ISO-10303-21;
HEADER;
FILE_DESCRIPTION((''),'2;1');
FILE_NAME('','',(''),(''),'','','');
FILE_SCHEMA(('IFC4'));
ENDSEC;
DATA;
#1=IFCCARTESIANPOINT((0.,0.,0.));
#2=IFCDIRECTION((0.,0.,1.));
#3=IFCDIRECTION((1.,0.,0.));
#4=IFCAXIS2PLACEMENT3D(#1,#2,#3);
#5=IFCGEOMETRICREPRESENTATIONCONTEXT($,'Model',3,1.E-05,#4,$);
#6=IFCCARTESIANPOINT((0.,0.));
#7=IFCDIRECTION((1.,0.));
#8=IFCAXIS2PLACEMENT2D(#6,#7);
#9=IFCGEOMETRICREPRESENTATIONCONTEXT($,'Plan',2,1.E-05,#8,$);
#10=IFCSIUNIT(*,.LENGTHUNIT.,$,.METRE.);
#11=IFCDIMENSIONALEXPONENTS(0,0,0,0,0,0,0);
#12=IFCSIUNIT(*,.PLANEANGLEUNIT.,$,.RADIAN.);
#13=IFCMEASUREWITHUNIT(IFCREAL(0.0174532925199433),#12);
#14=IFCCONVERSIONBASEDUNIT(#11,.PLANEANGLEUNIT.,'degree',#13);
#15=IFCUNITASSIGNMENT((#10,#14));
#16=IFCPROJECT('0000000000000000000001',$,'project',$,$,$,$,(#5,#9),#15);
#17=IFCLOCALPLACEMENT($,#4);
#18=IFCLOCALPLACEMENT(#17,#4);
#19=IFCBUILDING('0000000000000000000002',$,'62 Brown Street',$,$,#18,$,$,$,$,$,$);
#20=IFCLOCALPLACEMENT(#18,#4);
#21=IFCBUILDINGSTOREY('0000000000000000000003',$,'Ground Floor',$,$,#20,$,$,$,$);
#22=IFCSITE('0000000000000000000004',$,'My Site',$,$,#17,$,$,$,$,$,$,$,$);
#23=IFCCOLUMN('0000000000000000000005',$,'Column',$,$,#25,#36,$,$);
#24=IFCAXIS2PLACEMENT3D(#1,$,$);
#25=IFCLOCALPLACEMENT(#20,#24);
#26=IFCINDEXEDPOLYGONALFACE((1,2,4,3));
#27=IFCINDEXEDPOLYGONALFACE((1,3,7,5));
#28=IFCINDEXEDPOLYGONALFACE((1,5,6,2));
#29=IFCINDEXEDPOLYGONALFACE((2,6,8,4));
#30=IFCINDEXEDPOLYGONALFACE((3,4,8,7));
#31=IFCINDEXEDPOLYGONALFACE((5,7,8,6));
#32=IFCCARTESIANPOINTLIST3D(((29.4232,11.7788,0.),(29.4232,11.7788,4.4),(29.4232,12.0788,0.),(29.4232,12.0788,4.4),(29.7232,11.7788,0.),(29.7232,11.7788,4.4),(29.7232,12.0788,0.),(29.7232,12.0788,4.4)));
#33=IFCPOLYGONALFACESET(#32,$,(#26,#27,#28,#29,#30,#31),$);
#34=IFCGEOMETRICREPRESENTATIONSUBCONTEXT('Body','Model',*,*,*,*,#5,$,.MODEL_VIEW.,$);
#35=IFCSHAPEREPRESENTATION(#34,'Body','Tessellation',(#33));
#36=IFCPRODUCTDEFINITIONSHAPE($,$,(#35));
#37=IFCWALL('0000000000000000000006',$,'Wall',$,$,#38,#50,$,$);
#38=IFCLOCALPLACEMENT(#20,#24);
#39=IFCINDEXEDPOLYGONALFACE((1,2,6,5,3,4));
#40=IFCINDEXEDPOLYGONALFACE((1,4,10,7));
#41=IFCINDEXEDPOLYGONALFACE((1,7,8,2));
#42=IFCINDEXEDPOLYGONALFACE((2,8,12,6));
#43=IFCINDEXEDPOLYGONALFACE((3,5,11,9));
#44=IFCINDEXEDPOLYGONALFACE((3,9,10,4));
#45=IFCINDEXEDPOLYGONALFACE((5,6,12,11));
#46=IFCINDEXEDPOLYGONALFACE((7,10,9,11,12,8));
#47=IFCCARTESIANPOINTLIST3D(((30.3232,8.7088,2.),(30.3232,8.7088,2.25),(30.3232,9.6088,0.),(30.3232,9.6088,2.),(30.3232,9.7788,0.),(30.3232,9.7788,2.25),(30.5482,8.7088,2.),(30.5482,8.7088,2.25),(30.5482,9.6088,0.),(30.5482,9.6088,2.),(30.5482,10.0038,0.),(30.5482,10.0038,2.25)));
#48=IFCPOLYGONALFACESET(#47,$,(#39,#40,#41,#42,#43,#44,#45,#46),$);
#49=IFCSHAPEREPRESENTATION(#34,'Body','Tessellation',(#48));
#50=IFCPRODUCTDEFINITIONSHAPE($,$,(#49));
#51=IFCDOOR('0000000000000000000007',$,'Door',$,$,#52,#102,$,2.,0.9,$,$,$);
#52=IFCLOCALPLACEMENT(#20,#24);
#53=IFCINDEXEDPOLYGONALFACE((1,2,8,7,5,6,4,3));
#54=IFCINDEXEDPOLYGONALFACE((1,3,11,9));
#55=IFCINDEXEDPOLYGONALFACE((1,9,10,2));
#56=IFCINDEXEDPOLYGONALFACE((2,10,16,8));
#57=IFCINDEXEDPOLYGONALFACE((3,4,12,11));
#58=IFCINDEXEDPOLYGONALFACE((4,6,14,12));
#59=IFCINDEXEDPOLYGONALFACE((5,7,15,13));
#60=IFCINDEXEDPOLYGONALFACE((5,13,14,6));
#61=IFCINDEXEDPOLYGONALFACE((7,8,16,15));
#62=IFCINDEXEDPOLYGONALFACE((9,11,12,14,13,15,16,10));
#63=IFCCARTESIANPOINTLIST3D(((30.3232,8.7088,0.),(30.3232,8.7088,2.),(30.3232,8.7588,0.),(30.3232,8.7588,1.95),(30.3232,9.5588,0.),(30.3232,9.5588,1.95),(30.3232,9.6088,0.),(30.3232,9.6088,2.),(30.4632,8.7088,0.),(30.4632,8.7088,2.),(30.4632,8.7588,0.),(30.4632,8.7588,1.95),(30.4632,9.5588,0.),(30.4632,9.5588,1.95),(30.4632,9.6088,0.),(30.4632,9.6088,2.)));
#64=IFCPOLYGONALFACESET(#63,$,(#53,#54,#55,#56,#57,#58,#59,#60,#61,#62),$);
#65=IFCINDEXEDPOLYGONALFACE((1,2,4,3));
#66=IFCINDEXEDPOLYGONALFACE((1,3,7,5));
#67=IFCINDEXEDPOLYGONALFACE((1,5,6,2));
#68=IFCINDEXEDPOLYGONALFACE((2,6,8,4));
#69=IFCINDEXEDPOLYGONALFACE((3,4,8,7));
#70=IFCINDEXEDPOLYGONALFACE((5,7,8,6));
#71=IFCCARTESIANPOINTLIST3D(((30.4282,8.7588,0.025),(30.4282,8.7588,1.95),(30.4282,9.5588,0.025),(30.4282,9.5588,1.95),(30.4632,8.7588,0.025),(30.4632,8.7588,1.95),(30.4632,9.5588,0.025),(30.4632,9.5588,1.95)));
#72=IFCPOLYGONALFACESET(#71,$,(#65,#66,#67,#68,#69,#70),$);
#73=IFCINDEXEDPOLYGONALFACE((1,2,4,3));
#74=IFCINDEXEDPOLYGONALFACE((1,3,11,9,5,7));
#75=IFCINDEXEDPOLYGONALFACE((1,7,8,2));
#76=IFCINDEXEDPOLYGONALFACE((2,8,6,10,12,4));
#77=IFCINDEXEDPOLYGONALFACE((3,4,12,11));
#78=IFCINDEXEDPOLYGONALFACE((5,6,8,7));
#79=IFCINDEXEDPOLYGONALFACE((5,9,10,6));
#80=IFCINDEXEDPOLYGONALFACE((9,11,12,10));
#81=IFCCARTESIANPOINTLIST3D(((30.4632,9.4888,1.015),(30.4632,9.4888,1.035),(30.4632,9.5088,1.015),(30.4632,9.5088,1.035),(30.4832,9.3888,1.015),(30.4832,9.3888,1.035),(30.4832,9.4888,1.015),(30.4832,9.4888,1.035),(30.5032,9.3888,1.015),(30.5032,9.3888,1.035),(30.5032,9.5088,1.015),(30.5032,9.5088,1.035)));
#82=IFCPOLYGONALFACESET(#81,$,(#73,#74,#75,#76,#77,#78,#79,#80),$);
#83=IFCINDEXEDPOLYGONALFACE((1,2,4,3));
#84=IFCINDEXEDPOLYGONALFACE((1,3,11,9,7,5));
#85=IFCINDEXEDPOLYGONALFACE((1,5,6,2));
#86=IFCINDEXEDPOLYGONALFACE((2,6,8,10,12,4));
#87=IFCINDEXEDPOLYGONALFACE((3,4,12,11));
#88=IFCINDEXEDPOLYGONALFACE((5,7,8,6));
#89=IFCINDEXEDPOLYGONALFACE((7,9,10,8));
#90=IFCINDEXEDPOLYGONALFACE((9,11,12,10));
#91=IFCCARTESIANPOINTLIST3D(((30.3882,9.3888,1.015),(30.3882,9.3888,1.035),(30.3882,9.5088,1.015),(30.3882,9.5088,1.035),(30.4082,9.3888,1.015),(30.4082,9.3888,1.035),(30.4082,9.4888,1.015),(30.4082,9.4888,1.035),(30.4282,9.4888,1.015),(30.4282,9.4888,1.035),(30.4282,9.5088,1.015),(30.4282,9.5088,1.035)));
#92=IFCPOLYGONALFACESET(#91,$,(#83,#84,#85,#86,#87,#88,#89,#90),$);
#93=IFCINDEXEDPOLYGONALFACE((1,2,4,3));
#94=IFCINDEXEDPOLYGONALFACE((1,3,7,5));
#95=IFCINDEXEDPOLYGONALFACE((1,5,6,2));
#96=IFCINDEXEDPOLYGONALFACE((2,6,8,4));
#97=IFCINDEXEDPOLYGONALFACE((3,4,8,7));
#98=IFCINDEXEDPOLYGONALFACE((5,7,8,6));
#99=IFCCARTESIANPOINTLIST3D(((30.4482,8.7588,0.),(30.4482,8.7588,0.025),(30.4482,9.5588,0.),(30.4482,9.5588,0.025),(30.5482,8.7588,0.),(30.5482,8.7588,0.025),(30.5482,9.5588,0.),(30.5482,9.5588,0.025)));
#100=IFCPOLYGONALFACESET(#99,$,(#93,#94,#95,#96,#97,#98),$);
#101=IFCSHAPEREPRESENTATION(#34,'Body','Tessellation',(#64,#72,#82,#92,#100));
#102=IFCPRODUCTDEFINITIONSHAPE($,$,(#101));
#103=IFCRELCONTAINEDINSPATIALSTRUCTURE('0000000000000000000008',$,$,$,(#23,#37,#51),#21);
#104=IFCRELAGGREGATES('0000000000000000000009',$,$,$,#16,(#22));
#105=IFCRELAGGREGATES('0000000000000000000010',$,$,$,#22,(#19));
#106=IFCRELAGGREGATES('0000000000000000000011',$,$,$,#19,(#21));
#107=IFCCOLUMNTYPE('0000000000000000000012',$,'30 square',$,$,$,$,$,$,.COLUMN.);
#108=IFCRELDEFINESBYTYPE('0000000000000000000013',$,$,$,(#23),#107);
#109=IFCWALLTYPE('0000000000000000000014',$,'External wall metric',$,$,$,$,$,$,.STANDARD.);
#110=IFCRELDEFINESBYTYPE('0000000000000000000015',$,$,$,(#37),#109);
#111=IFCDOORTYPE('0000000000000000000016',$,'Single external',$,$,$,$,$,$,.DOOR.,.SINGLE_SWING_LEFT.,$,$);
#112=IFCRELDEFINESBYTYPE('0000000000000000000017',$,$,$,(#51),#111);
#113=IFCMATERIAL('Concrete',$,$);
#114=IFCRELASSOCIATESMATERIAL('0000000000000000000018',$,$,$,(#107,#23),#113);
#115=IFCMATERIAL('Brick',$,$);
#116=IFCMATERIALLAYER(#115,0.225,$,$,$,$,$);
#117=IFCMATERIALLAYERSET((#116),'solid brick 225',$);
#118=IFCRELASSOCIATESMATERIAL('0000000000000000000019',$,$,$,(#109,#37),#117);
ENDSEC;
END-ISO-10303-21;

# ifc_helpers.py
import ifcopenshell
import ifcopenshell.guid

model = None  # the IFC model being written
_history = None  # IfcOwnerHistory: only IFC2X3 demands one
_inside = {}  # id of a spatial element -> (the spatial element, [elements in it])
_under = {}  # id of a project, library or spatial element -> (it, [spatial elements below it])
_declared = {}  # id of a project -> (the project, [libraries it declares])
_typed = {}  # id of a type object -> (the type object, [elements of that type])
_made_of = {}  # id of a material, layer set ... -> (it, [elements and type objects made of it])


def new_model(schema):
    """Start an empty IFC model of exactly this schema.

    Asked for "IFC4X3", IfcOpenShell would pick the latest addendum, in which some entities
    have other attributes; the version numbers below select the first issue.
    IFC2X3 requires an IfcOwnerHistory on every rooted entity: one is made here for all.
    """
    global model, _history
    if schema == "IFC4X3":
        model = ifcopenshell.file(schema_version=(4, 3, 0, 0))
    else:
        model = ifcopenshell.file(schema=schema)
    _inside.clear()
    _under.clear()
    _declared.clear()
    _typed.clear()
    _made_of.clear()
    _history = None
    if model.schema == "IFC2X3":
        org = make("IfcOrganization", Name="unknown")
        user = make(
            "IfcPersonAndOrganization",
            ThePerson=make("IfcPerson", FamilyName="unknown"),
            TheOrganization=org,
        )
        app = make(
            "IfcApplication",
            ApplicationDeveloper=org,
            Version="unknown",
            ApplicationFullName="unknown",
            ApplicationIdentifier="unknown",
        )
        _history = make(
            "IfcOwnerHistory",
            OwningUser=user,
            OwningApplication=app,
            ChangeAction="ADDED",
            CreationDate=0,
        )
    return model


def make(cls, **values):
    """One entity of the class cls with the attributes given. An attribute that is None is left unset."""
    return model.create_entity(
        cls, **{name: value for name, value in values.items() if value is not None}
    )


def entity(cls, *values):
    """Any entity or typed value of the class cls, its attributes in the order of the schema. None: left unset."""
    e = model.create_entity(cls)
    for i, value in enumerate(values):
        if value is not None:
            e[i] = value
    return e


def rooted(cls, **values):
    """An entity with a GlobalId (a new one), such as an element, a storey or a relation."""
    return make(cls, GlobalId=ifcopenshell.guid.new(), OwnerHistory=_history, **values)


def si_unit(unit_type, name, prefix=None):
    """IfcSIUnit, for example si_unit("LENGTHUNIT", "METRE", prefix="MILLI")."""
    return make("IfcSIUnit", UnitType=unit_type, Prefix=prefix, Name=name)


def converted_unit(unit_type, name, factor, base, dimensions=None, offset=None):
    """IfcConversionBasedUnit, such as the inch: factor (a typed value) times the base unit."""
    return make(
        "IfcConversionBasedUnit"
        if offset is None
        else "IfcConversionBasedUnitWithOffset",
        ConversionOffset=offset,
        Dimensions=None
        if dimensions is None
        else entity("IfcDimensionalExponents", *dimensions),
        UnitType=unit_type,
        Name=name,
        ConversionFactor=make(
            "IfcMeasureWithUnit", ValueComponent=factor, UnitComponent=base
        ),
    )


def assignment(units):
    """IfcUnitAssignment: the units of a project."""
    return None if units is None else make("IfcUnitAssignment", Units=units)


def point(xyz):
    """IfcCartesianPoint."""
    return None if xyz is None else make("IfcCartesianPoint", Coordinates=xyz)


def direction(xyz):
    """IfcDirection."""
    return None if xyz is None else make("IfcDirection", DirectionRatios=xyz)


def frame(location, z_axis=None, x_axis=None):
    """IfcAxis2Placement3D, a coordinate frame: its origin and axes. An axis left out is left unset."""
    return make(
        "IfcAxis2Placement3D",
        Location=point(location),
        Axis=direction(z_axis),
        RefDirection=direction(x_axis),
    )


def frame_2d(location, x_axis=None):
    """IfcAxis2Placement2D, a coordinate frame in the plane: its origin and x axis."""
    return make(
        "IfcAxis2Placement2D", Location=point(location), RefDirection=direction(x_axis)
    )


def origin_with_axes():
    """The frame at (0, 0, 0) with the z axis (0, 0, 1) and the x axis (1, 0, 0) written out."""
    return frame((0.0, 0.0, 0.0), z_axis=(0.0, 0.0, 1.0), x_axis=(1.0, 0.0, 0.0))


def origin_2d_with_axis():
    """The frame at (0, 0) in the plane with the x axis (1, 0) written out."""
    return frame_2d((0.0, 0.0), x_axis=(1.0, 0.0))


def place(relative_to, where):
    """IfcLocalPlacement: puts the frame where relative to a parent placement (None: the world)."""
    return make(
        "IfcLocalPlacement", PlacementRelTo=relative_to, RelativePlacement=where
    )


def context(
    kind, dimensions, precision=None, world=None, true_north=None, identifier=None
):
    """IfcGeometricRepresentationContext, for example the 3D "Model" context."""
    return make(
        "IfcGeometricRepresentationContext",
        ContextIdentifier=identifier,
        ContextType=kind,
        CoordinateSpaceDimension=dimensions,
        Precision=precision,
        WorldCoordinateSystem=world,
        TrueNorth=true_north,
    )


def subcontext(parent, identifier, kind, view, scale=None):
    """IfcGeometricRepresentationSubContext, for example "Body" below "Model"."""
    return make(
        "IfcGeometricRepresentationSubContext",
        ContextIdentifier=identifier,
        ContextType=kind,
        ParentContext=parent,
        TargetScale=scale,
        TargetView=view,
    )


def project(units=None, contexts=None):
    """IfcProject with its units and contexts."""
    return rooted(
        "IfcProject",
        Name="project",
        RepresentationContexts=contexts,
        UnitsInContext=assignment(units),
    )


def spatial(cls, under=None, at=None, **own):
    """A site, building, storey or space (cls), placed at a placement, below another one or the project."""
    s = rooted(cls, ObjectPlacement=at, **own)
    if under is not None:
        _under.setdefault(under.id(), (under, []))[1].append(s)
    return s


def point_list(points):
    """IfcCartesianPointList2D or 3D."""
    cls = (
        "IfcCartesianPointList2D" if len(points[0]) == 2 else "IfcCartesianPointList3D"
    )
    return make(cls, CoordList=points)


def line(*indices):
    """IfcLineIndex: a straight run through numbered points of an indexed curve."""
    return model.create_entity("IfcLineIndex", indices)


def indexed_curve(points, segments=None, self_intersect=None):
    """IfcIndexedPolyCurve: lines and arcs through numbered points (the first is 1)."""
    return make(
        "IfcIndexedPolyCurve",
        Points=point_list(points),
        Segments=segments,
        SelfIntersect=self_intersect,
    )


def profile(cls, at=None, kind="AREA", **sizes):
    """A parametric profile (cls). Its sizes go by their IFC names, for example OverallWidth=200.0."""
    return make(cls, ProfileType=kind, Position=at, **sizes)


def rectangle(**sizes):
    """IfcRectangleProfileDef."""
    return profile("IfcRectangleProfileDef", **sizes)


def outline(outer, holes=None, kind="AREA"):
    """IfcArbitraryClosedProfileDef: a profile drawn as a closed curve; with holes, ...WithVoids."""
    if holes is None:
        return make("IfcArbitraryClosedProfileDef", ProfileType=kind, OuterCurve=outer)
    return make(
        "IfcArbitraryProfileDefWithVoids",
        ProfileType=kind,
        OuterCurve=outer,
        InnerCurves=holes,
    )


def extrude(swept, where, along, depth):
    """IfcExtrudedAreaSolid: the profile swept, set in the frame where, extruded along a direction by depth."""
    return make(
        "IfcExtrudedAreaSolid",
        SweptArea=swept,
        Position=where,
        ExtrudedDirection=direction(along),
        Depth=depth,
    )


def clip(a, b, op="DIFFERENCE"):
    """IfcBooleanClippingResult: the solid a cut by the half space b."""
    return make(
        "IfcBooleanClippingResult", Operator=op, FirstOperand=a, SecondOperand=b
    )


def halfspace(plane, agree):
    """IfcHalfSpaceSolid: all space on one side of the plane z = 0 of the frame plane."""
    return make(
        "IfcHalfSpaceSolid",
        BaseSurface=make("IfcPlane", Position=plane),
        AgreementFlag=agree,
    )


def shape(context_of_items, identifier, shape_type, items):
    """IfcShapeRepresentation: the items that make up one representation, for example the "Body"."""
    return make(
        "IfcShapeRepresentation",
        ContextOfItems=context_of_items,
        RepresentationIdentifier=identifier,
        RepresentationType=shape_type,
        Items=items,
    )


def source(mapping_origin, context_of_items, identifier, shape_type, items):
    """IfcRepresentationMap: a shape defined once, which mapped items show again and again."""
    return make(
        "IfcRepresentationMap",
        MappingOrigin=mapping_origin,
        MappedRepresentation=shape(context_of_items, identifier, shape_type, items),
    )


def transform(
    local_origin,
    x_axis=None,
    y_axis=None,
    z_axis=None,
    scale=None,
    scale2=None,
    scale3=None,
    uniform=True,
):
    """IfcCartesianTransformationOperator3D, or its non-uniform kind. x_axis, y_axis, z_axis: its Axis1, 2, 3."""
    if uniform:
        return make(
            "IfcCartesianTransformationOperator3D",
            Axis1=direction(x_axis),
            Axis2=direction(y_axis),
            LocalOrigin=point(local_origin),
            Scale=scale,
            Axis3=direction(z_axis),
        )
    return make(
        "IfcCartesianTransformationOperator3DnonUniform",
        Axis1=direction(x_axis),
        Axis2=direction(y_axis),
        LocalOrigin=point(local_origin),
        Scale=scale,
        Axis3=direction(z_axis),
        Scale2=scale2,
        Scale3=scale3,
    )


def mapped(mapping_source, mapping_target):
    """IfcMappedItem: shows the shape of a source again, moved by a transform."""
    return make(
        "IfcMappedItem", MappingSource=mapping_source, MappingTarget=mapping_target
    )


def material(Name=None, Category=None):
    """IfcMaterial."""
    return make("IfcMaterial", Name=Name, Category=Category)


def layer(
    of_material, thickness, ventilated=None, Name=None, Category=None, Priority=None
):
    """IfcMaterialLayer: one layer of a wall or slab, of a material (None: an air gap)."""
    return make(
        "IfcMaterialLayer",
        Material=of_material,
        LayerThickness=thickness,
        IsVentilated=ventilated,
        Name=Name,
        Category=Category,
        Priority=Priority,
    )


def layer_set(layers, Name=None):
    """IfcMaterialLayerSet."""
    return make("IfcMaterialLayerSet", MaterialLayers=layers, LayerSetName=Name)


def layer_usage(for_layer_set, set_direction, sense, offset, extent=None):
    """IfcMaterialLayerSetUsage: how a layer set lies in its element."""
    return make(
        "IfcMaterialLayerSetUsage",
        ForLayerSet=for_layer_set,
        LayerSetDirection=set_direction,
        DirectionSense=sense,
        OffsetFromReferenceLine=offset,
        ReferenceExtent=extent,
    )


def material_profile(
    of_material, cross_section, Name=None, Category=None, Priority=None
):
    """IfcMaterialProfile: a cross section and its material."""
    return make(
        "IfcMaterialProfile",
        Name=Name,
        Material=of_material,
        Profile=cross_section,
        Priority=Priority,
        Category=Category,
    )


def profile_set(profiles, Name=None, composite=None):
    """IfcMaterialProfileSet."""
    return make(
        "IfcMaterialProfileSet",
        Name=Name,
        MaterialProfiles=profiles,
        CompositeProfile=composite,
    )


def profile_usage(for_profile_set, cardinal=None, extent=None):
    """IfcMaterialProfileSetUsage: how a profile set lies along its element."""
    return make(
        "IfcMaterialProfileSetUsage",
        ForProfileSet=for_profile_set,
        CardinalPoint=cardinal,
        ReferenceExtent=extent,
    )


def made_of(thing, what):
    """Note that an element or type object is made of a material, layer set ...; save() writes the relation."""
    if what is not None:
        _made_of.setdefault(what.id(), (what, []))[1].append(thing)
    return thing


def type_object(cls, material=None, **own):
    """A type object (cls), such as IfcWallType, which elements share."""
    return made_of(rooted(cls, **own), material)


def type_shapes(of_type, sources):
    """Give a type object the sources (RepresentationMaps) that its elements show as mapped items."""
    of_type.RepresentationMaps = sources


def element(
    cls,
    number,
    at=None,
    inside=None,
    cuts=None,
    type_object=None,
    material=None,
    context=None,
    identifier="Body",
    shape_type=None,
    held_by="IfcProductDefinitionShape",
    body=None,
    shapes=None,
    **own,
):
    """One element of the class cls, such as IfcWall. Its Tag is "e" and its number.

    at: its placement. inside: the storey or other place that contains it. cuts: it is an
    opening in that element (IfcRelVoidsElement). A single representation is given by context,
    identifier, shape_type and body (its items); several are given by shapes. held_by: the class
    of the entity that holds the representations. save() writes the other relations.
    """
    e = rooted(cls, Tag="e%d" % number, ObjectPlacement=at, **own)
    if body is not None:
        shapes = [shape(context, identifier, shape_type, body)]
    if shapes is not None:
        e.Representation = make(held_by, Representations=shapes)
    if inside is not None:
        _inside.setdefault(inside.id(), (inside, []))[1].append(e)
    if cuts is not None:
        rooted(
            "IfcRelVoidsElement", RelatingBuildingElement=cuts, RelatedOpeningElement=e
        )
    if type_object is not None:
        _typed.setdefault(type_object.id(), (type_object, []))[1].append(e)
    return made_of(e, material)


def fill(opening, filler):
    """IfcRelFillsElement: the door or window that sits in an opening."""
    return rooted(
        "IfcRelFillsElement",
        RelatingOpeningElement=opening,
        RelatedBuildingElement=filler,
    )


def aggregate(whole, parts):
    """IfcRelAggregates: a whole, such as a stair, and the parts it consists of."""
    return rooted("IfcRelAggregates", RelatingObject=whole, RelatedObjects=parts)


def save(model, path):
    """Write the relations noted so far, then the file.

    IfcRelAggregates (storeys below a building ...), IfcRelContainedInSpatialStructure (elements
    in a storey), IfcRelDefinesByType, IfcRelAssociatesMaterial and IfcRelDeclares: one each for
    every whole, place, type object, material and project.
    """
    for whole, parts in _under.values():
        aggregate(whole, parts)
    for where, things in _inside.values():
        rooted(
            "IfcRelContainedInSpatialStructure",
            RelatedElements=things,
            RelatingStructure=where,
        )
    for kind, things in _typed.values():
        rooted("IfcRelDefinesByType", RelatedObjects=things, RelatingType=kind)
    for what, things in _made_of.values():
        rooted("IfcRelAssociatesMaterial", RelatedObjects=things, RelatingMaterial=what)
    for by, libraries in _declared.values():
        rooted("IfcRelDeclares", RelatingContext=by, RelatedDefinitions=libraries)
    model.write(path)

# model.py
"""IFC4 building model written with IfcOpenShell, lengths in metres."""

from ifc_helpers import new_model, entity, si_unit, converted_unit, frame, origin_with_axes, origin_2d_with_axis, place, context, subcontext, project, spatial, line, indexed_curve, rectangle, outline, extrude, clip, halfspace, shape, source, transform, mapped, material, layer, layer_set, layer_usage, material_profile, profile_set, profile_usage, type_object, type_shapes, element, fill, save


model = new_model("IFC4")

# Units and contexts
model_context = context("Model", 3, precision=1e-05, world=origin_with_axes())
plan_context = context("Plan", 2, precision=1e-05, world=origin_2d_with_axis())
body_context_1 = subcontext(model_context, "Body", "Model", "MODEL_VIEW")
body_context_2 = subcontext(plan_context, "Body", "Plan", "PLAN_VIEW")
ifc_project = project(units=[si_unit("LENGTHUNIT", "METRE"), converted_unit("PLANEANGLEUNIT", "degree", entity("IfcReal", 0.0174532925199433), si_unit("PLANEANGLEUNIT", "RADIAN"), dimensions=[0, 0, 0, 0, 0, 0, 0])], contexts=[model_context, plan_context])

# Site, building, storey
site_placement = place(None, origin_with_axes())
site = spatial("IfcSite", under=ifc_project, at=site_placement, Name="My Site")
building_placement = place(site_placement, origin_with_axes())
building = spatial("IfcBuilding", under=site, at=building_placement, Name="62 Brown Street")
storey_placement = place(building_placement, origin_with_axes())
storey = spatial("IfcBuildingStorey", under=building, at=storey_placement, Name="Ground Floor")

# Column
ifc_material_1 = material(Name="Concrete")
ifc_material_profile = material_profile(ifc_material_1, rectangle(XDim=0.3, YDim=0.3))
ifc_profile_set = profile_set([ifc_material_profile])
ifc_profile_usage = profile_usage(ifc_profile_set, cardinal=5)
column_type = type_object("IfcColumnType", Name="30 square", PredefinedType="COLUMN", material=ifc_profile_set)
column_placement = place(storey_placement, frame((29.5732, 11.9288, 0.0), z_axis=(0.0, 0.0, 1.0), x_axis=(1.0, 0.0, 0.0)))
element("IfcColumn", 1, at=column_placement, inside=storey, type_object=column_type, material=ifc_profile_usage, Name="Column", context=body_context_1, shape_type="SweptSolid", body=[
    extrude(rectangle(XDim=0.3, YDim=0.3), origin_with_axes(), (0.0, 0.0, 1.0), 4.4),
])

# Shared definitions
ifc_material_2 = material(Name="Brick")
ifc_layer_1 = layer(ifc_material_2, 0.225)
ifc_layer_set_1 = layer_set([ifc_layer_1], Name="solid brick 225")
wall_type_1 = type_object("IfcWallType", Name="External wall metric", PredefinedType="STANDARD", material=ifc_layer_set_1)

# Wall, opening, door
ifc_layer_usage_1 = layer_usage(ifc_layer_set_1, "AXIS2", "POSITIVE", 0.0)
wall_1_placement = place(storey_placement, frame((30.5482, 8.7088, 0.0), z_axis=(0.0, 0.0, 1.0), x_axis=(0.0, 1.0, 0.0)))
wall_1 = element("IfcWall", 2, at=wall_1_placement, inside=storey, type_object=wall_type_1, material=ifc_layer_usage_1, Name="Wall", context=body_context_1, shape_type="Clipping", body=[
    clip(extrude(outline(indexed_curve([(0.0, 0.0), (0.0, 0.225), (1.295, 0.225), (1.295, 0.0), (0.0, 0.0)], self_intersect=False)), origin_with_axes(), (0.0, 0.0, 1.0), 2.25), halfspace(frame((1.295, 0.0, 0.0), z_axis=(0.506251, 0.506251, 0.0), x_axis=(-0.225, 0.225, 0.0)), False)),
])
shared_shape_1 = source(origin_with_axes(), body_context_1, "Body", "SweptSolid", [
    extrude(outline(indexed_curve([(0.0, 0.0), (0.9, 0.0), (0.9, 2.0), (0.0, 2.0)], segments=[line(1, 2, 3, 4, 1)])), frame((0.0, -0.6, 0.0), z_axis=(0.0, -1.0, 0.0), x_axis=(1.0, 0.0, 0.0)), (0.0, 0.0, -1.0), 1.2),
])
opening_1_placement = place(wall_1_placement, frame((0.0, 0.0, 0.0), z_axis=(0.0, 0.0, 1.0), x_axis=(1.0, 0.0, 0.0)))
opening_1 = element("IfcOpeningElement", 3, at=opening_1_placement, cuts=wall_1, PredefinedType="OPENING", context=body_context_1, shape_type="MappedRepresentation", body=[
    mapped(shared_shape_1, transform((0.0, 0.0, 0.0), x_axis=(1.0, 0.0, 0.0), y_axis=(0.0, 1.0, 0.0), z_axis=(0.0, 0.0, 1.0), scale=1.0)),
])
door_type_1 = type_object("IfcDoorType", Name="Single external", OperationType="SINGLE_SWING_LEFT", PredefinedType="DOOR")
shared_shape_2 = source(origin_with_axes(), body_context_1, "Body", "SweptSolid", [
    extrude(outline(indexed_curve([(0.0, 0.0), (0.0, 2.0), (0.9, 2.0), (0.9, 0.0), (0.85, 0.0), (0.85, 1.95), (0.05, 1.95), (0.05, 0.0)], segments=[line(1, 2, 3, 4, 5, 6, 7, 8, 1)])), frame((0.0, 0.085, 0.0), z_axis=(0.0, -1.0, 0.0), x_axis=(1.0, 0.0, 0.0)), (0.0, 0.0, -1.0), 0.14),
    extrude(outline(indexed_curve([(0.0, 0.0), (0.8, 0.0), (0.8, 0.035), (0.0, 0.035)], segments=[line(1, 2, 3, 4, 1)])), frame((0.05, 0.085, 0.025), z_axis=(0.0, 0.0, 1.0), x_axis=(1.0, 0.0, 0.0)), (0.0, 0.0, 1.0), 1.925),
    extrude(outline(indexed_curve([(0.0, 0.0), (0.0, -0.04), (-0.12, -0.04), (-0.12, -0.02), (-0.02, -0.02), (-0.02, 0.0)], segments=[line(1, 2, 3, 4, 5, 6, 1)])), frame((0.8, 0.085, 1.015), z_axis=(0.0, 0.0, 1.0), x_axis=(1.0, 0.0, 0.0)), (0.0, 0.0, 1.0), 0.02),
    extrude(outline(indexed_curve([(0.0, 0.0), (0.0, 0.04), (-0.12, 0.04), (-0.12, 0.02), (-0.02, 0.02), (-0.02, 0.0)], segments=[line(1, 2, 3, 4, 5, 6, 1)])), frame((0.8, 0.12, 1.015), z_axis=(0.0, 0.0, 1.0), x_axis=(1.0, 0.0, 0.0)), (0.0, 0.0, 1.0), 0.02),
    extrude(outline(indexed_curve([(0.0, 0.0), (0.8, 0.0), (0.8, 0.1), (0.0, 0.1)], segments=[line(1, 2, 3, 4, 1)])), frame((0.05, 0.0, 0.0), z_axis=(0.0, 0.0, 1.0), x_axis=(1.0, 0.0, 0.0)), (0.0, 0.0, 1.0), 0.025),
])
shared_shape_3 = source(origin_with_axes(), body_context_2, "Body", "Curve2D", [
    entity("IfcIndexedPolyCurve", entity("IfcCartesianPointList2D", [[0.0, 0.085], [0.05, 0.085], [0.05, 0.225], [0.0, 0.225]]), [entity("IfcLineIndex", [1, 2, 3, 4, 1])]),
    entity("IfcIndexedPolyCurve", entity("IfcCartesianPointList2D", [[0.9, 0.085], [0.85, 0.085], [0.85, 0.225], [0.9, 0.225]]), [entity("IfcLineIndex", [1, 2, 3, 4, 1])]),
    entity("IfcTrimmedCurve", entity("IfcEllipse", entity("IfcAxis2Placement2D", entity("IfcCartesianPoint", [0.085, 0.225]), entity("IfcDirection", [1.0, 0.0])), 0.765, 0.8), [entity("IfcCartesianPoint", [0.85, 0.225])], [entity("IfcCartesianPoint", [0.085, 1.025])], True, "CARTESIAN"),
    entity("IfcIndexedPolyCurve", entity("IfcCartesianPointList2D", [[0.05, 0.225], [0.085, 0.225], [0.085, 1.025], [0.05, 1.025]]), [entity("IfcLineIndex", [1, 2, 3, 4, 1])]),
])
type_shapes(door_type_1, [shared_shape_2, shared_shape_3])
door_1_placement = place(opening_1_placement, frame((0.0, 0.0, 0.0), z_axis=(0.0, 0.0, 1.0), x_axis=(1.0, 0.0, 0.0)))
door_1 = element("IfcDoor", 4, at=door_1_placement, inside=storey, type_object=door_type_1, Name="Door", OverallHeight=2.0, OverallWidth=0.9, shapes=[
    shape(body_context_1, "Body", "MappedRepresentation", [mapped(shared_shape_2, transform((0.0, 0.0, 0.0), x_axis=(1.0, 0.0, 0.0), y_axis=(0.0, 1.0, 0.0), z_axis=(0.0, 0.0, 1.0), scale=1.0))]),
    shape(body_context_2, "Body", "MappedRepresentation", [mapped(shared_shape_3, transform((0.0, 0.0, 0.0), x_axis=(1.0, 0.0, 0.0), y_axis=(0.0, 1.0, 0.0), z_axis=(0.0, 0.0, 1.0), scale=1.0))]),
])
fill(opening_1, door_1)

save(model, "model.ifc")
